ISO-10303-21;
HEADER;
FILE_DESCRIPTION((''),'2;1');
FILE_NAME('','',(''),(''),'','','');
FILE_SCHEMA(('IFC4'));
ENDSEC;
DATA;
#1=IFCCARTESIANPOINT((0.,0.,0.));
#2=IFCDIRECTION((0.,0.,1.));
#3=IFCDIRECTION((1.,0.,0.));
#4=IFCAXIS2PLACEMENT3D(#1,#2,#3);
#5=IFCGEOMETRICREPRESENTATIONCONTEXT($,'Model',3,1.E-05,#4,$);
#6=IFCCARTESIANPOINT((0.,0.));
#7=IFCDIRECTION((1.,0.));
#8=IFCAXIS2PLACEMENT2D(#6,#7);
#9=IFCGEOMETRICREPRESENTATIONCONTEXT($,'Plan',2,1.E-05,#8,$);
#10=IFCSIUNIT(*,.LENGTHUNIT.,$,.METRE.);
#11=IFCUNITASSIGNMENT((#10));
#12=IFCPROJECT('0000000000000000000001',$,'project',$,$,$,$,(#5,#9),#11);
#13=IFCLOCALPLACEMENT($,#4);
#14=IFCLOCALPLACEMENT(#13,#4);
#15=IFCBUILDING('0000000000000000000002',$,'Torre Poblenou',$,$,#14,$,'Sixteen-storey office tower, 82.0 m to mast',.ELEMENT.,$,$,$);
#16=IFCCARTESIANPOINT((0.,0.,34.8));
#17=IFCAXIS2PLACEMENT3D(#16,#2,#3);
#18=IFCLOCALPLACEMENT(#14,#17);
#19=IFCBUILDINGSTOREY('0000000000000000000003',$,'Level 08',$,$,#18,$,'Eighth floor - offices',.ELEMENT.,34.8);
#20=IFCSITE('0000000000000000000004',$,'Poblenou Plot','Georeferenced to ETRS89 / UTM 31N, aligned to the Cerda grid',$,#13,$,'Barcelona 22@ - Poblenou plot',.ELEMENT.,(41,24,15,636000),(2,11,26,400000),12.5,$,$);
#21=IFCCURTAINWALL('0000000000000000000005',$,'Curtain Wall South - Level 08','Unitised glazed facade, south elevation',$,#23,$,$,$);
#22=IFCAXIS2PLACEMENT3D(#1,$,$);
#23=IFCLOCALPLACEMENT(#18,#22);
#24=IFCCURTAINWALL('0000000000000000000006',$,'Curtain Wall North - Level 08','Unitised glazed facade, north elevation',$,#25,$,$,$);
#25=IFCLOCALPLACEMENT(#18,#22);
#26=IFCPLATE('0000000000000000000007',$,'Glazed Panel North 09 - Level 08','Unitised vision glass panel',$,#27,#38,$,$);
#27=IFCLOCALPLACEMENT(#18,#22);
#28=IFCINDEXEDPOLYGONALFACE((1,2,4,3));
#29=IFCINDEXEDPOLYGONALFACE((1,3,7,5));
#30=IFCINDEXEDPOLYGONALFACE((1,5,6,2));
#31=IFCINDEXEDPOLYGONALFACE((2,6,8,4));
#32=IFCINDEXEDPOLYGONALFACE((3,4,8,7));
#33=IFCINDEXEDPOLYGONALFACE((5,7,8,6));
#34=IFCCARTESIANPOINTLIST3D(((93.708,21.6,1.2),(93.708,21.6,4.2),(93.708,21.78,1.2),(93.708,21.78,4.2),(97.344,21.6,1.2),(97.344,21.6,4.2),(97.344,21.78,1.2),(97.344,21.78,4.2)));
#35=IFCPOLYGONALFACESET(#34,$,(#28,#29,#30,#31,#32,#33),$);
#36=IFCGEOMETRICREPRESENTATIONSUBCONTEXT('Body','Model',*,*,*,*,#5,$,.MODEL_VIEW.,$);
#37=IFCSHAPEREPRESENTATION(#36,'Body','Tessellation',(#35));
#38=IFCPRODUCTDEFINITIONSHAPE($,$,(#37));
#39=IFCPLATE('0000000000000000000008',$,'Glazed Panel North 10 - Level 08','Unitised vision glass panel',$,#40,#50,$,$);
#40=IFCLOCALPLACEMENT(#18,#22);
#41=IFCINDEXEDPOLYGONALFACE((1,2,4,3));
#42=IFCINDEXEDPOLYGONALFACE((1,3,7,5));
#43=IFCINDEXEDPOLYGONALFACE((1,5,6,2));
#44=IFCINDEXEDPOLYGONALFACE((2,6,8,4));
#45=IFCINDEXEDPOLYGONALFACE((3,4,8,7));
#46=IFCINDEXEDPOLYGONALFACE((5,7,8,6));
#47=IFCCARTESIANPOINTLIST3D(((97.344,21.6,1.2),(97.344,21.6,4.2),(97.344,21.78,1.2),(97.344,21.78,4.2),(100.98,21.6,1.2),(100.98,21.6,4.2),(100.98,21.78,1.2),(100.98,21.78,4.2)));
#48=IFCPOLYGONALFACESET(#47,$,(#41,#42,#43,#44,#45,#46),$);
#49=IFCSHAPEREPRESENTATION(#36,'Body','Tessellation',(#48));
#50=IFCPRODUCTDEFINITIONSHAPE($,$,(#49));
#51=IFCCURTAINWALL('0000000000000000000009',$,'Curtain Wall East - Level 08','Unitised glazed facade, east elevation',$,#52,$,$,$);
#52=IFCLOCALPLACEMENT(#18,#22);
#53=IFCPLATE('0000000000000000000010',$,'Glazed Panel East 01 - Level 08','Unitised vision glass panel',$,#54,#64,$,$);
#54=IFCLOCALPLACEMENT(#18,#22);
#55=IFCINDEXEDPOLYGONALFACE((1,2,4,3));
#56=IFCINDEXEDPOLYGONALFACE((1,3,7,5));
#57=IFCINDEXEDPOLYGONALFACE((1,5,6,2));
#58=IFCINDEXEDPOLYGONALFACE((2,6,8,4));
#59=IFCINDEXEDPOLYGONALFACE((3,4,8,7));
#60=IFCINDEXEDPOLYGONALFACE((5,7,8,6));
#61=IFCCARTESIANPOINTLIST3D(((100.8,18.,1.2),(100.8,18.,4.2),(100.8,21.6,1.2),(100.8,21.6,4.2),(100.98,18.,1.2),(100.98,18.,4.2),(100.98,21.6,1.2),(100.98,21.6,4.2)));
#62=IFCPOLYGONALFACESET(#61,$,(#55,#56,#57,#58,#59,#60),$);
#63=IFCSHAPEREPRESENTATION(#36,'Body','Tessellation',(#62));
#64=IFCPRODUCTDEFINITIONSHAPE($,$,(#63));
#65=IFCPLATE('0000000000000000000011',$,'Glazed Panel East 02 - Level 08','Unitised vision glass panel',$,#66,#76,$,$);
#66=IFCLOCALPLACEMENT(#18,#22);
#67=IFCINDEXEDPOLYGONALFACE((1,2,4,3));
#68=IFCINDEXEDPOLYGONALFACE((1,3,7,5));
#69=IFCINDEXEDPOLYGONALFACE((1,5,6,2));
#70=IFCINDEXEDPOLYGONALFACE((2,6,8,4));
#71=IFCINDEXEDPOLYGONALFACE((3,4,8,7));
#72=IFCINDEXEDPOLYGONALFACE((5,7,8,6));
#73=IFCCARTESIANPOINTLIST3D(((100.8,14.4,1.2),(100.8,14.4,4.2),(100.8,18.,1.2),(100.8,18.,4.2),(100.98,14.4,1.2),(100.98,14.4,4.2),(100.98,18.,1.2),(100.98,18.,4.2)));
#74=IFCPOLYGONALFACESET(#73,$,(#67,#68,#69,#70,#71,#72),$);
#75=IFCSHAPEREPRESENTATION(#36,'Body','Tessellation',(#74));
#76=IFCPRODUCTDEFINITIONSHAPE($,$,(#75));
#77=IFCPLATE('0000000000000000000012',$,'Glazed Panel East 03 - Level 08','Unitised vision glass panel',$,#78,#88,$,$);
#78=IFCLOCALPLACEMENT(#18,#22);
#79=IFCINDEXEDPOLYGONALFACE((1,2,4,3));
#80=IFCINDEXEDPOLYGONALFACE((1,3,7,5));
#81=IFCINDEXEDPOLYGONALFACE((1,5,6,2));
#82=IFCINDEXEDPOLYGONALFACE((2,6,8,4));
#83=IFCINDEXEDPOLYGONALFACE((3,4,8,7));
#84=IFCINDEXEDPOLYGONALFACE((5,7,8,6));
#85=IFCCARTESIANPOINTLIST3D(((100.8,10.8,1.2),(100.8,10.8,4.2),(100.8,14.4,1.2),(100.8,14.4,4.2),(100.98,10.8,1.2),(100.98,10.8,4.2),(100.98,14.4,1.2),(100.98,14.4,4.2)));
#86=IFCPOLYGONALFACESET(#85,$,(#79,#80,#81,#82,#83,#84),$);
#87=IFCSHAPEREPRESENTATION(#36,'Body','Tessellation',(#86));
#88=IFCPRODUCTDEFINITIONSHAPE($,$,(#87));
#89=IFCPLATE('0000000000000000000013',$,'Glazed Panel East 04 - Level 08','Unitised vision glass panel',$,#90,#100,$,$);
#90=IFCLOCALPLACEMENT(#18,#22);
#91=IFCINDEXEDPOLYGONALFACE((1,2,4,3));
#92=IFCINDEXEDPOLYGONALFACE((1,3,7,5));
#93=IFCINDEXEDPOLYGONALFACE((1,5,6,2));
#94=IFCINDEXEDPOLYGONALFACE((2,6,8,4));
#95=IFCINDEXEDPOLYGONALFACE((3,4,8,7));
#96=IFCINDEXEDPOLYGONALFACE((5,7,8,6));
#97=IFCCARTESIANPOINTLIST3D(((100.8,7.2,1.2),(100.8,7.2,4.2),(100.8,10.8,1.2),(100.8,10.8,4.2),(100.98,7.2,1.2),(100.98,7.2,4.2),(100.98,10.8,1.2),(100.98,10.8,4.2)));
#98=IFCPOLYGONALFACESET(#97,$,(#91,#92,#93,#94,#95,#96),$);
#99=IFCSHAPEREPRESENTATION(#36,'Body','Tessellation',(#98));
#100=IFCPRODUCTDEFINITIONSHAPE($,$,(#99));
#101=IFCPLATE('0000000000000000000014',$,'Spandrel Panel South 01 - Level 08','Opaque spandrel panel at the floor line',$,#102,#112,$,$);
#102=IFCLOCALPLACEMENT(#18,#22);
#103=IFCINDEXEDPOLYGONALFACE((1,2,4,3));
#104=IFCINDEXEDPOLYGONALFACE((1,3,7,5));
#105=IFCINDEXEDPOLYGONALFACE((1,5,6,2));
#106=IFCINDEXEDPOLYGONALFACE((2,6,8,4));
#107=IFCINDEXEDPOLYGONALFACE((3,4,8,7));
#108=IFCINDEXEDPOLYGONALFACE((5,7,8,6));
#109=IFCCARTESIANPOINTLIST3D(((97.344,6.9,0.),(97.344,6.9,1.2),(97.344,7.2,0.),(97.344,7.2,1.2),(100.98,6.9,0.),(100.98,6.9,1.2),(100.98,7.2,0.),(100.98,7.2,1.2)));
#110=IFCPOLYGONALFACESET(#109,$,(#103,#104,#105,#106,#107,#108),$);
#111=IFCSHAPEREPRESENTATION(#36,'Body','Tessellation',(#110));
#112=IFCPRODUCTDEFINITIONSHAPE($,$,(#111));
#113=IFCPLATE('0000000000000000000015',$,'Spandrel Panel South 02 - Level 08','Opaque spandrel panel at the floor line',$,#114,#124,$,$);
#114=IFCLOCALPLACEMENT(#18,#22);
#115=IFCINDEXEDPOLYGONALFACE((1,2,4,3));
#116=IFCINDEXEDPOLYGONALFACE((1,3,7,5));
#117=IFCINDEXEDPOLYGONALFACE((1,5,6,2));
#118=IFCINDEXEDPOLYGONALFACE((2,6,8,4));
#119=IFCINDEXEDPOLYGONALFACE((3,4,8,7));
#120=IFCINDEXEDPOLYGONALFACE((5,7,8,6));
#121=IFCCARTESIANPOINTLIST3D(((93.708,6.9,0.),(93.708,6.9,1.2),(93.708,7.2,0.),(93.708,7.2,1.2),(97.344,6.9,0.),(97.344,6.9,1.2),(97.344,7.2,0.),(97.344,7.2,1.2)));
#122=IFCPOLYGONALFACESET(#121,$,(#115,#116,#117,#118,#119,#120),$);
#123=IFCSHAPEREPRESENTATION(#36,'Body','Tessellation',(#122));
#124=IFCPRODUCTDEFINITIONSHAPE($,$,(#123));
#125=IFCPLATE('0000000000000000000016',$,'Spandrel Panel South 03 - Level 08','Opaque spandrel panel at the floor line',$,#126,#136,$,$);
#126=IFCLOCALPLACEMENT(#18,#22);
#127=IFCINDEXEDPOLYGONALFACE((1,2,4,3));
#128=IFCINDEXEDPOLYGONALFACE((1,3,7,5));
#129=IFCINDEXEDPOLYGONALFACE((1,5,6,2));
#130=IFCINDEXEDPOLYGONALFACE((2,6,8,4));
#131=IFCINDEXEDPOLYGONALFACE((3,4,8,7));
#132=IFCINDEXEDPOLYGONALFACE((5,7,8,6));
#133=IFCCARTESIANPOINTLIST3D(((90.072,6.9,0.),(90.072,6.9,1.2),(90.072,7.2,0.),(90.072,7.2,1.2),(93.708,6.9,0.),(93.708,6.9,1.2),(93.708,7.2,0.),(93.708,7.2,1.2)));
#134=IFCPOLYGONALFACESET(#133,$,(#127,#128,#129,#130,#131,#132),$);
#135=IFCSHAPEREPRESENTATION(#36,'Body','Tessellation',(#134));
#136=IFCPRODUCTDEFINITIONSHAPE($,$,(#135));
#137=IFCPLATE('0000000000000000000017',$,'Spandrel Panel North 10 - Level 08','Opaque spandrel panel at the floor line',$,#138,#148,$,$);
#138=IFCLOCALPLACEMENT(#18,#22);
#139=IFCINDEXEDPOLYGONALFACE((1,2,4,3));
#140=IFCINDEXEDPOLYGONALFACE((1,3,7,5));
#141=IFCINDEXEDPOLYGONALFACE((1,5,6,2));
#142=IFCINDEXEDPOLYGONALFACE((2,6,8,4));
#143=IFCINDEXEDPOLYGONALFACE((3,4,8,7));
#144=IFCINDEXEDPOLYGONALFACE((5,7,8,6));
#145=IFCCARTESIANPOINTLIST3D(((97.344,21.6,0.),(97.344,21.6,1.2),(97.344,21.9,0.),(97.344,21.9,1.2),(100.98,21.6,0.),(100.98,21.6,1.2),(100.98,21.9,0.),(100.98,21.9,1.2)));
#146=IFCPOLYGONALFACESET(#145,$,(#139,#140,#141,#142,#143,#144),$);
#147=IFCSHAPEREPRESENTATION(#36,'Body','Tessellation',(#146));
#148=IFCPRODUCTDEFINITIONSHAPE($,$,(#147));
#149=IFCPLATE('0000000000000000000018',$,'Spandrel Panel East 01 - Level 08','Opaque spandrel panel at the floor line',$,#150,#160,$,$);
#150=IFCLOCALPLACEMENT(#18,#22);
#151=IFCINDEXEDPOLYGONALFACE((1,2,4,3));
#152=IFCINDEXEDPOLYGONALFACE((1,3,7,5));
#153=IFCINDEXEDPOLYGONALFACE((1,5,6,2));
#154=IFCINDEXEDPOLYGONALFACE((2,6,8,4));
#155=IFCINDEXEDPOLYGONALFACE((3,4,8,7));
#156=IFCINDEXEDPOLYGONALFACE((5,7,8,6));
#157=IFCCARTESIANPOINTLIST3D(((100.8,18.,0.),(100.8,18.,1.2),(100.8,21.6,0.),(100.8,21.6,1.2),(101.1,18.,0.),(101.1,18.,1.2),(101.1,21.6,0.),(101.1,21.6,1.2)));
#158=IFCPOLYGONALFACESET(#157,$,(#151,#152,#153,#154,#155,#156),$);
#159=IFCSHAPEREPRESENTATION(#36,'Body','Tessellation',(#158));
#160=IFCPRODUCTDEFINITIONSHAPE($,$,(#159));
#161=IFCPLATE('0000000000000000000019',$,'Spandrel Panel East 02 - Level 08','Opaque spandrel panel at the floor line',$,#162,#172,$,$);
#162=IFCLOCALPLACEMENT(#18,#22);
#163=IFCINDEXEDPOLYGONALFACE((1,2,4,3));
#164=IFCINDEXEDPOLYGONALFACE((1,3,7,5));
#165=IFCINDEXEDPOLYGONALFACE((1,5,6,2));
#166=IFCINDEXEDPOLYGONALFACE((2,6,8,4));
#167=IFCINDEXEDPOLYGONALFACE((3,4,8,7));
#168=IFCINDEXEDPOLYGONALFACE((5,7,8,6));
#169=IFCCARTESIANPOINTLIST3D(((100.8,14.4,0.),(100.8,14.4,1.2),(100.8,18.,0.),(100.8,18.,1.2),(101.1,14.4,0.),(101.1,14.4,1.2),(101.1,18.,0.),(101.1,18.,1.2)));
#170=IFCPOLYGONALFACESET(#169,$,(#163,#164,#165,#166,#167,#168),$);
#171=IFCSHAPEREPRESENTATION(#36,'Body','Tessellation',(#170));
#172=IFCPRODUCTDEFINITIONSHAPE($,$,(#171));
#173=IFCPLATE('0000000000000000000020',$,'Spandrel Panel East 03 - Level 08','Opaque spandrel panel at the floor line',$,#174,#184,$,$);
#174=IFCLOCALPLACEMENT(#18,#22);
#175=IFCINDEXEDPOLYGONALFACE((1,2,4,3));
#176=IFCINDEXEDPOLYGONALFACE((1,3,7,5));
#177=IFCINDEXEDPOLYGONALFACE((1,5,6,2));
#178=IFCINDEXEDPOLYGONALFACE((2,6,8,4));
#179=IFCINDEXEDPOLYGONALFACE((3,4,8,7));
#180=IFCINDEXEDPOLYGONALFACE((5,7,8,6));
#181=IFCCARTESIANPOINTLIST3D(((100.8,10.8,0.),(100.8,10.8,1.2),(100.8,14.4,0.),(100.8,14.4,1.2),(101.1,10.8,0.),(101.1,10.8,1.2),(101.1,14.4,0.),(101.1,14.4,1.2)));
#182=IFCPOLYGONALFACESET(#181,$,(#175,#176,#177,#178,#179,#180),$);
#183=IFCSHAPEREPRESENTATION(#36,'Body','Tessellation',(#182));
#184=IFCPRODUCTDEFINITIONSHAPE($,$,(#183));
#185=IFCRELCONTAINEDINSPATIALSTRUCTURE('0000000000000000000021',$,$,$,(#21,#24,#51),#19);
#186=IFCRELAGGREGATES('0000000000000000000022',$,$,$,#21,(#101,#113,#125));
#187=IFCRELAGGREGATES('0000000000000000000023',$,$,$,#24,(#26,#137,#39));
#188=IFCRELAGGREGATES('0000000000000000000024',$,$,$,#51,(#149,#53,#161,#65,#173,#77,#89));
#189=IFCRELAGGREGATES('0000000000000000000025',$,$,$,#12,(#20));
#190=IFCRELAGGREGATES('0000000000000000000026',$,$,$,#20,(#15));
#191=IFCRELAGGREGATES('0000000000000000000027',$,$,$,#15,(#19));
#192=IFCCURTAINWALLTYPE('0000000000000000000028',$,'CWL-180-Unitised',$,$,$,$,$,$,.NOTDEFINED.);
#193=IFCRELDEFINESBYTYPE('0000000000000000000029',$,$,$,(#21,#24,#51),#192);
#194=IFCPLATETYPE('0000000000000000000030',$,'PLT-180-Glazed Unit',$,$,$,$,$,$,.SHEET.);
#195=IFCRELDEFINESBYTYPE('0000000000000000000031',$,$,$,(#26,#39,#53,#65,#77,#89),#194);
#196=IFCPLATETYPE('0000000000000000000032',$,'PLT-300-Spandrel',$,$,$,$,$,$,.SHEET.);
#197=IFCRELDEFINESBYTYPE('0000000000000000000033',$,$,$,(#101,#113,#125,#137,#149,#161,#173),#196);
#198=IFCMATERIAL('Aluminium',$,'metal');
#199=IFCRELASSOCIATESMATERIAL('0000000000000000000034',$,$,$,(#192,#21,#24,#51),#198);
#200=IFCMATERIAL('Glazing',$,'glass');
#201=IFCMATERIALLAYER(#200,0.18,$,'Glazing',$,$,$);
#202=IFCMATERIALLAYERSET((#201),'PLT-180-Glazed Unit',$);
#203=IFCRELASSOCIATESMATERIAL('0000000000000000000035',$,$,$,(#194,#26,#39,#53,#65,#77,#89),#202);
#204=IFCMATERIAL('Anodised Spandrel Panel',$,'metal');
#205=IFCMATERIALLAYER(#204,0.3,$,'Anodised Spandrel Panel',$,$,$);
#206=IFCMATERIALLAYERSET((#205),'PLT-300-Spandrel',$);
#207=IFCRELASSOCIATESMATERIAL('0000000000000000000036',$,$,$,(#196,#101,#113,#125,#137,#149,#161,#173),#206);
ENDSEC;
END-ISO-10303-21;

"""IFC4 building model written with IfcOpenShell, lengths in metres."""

from ifc_helpers import new_model, si_unit, frame, origin_with_axes, origin_2d_with_axis, place, context, subcontext, project, spatial, line, indexed_curve, outline, extrude, material, layer, layer_set, layer_usage, type_object, element, aggregate, save


model = new_model("IFC4")

# Units and contexts
model_context = context("Model", 3, precision=1e-05, world=origin_with_axes())
plan_context = context("Plan", 2, precision=1e-05, world=origin_2d_with_axis())
body_context = subcontext(model_context, "Body", "Model", "MODEL_VIEW")
ifc_project = project(units=[si_unit("LENGTHUNIT", "METRE")], contexts=[model_context, plan_context])

# Site, building, storey
site_placement = place(None, origin_with_axes())
site = spatial("IfcSite", under=ifc_project, at=site_placement, Name="Poblenou Plot", Description="Georeferenced to ETRS89 / UTM 31N, aligned to the Cerda grid", LongName="Barcelona 22@ - Poblenou plot", CompositionType="ELEMENT", RefLatitude=(41, 24, 15, 636000), RefLongitude=(2, 11, 26, 400000), RefElevation=12.5)
building_placement = place(site_placement, origin_with_axes())
building = spatial("IfcBuilding", under=site, at=building_placement, Name="Torre Poblenou", LongName="Sixteen-storey office tower, 82.0 m to mast", CompositionType="ELEMENT")
storey_placement = place(building_placement, frame((0.0, 0.0, 34.8), z_axis=(0.0, 0.0, 1.0), x_axis=(1.0, 0.0, 0.0)))
storey = spatial("IfcBuildingStorey", under=building, at=storey_placement, Name="Level 08", LongName="Eighth floor - offices", CompositionType="ELEMENT", Elevation=34.8)

# Curtain walls, plates
ifc_material_1 = material(Name="Aluminium", Category="metal")
curtain_wall_type = type_object("IfcCurtainWallType", Name="CWL-180-Unitised", PredefinedType="NOTDEFINED", material=ifc_material_1)
curtain_wall_1_placement = place(storey_placement, frame((100.98, 7.2, 0.0), z_axis=(0.0, 0.0, 1.0), x_axis=(-1.0, 0.0, 0.0)))
curtain_wall_1 = element("IfcCurtainWall", 1, at=curtain_wall_1_placement, inside=storey, type_object=curtain_wall_type, material=ifc_material_1, Name="Curtain Wall South - Level 08", Description="Unitised glazed facade, south elevation")
ifc_material_2 = material(Name="Glazing", Category="glass")
ifc_layer_1 = layer(ifc_material_2, 0.18, Name="Glazing")
ifc_layer_set_1 = layer_set([ifc_layer_1], Name="PLT-180-Glazed Unit")
plate_type_1 = type_object("IfcPlateType", Name="PLT-180-Glazed Unit", PredefinedType="SHEET", material=ifc_layer_set_1)
curtain_wall_2_placement = place(storey_placement, frame((64.62, 21.6, 0.0), z_axis=(0.0, 0.0, 1.0), x_axis=(1.0, 0.0, 0.0)))
curtain_wall_2 = element("IfcCurtainWall", 2, at=curtain_wall_2_placement, inside=storey, type_object=curtain_wall_type, material=ifc_material_1, Name="Curtain Wall North - Level 08", Description="Unitised glazed facade, north elevation")
ifc_layer_usage_1 = layer_usage(ifc_layer_set_1, "AXIS2", "POSITIVE", 0.0)
plate_1_placement = place(curtain_wall_2_placement, frame((29.088, 0.0, 1.2), z_axis=(0.0, 0.0, 1.0), x_axis=(1.0, 0.0, 0.0)))
plate_1 = element("IfcPlate", 3, at=plate_1_placement, type_object=plate_type_1, material=ifc_layer_usage_1, Name="Glazed Panel North 09 - Level 08", Description="Unitised vision glass panel", context=body_context, shape_type="SweptSolid", body=[
    extrude(outline(indexed_curve([(0.0, 0.0), (3.636, 0.0), (3.636, 0.18), (0.0, 0.18)], segments=[line(1, 2, 3, 4, 1)])), origin_with_axes(), (0.0, 0.0, 1.0), 3.0),
])
ifc_layer_usage_2 = layer_usage(ifc_layer_set_1, "AXIS2", "POSITIVE", 0.0)
plate_2_placement = place(curtain_wall_2_placement, frame((32.724, 0.0, 1.2), z_axis=(0.0, 0.0, 1.0), x_axis=(1.0, 0.0, 0.0)))
plate_2 = element("IfcPlate", 4, at=plate_2_placement, type_object=plate_type_1, material=ifc_layer_usage_2, Name="Glazed Panel North 10 - Level 08", Description="Unitised vision glass panel", context=body_context, shape_type="SweptSolid", body=[
    extrude(outline(indexed_curve([(0.0, 0.0), (3.636, 0.0), (3.636, 0.18), (0.0, 0.18)], segments=[line(1, 2, 3, 4, 1)])), origin_with_axes(), (0.0, 0.0, 1.0), 3.0),
])
curtain_wall_3_placement = place(storey_placement, frame((100.8, 21.6, 0.0), z_axis=(0.0, 0.0, 1.0), x_axis=(0.0, -1.0, 0.0)))
curtain_wall_3 = element("IfcCurtainWall", 5, at=curtain_wall_3_placement, inside=storey, type_object=curtain_wall_type, material=ifc_material_1, Name="Curtain Wall East - Level 08", Description="Unitised glazed facade, east elevation")
ifc_layer_usage_3 = layer_usage(ifc_layer_set_1, "AXIS2", "POSITIVE", 0.0)
plate_3_placement = place(curtain_wall_3_placement, frame((0.0, 0.0, 1.2), z_axis=(0.0, 0.0, 1.0), x_axis=(1.0, 0.0, 0.0)))
plate_3 = element("IfcPlate", 6, at=plate_3_placement, type_object=plate_type_1, material=ifc_layer_usage_3, Name="Glazed Panel East 01 - Level 08", Description="Unitised vision glass panel", context=body_context, shape_type="SweptSolid", body=[
    extrude(outline(indexed_curve([(0.0, 0.0), (3.6, 0.0), (3.6, 0.18), (0.0, 0.18)], segments=[line(1, 2, 3, 4, 1)])), origin_with_axes(), (0.0, 0.0, 1.0), 3.0),
])
ifc_layer_usage_4 = layer_usage(ifc_layer_set_1, "AXIS2", "POSITIVE", 0.0)
plate_4_placement = place(curtain_wall_3_placement, frame((3.6, 0.0, 1.2), z_axis=(0.0, 0.0, 1.0), x_axis=(1.0, 0.0, 0.0)))
plate_4 = element("IfcPlate", 7, at=plate_4_placement, type_object=plate_type_1, material=ifc_layer_usage_4, Name="Glazed Panel East 02 - Level 08", Description="Unitised vision glass panel", context=body_context, shape_type="SweptSolid", body=[
    extrude(outline(indexed_curve([(0.0, 0.0), (3.6, 0.0), (3.6, 0.18), (0.0, 0.18)], segments=[line(1, 2, 3, 4, 1)])), origin_with_axes(), (0.0, 0.0, 1.0), 3.0),
])
ifc_layer_usage_5 = layer_usage(ifc_layer_set_1, "AXIS2", "POSITIVE", 0.0)
plate_5_placement = place(curtain_wall_3_placement, frame((7.2, 0.0, 1.2), z_axis=(0.0, 0.0, 1.0), x_axis=(1.0, 0.0, 0.0)))
plate_5 = element("IfcPlate", 8, at=plate_5_placement, type_object=plate_type_1, material=ifc_layer_usage_5, Name="Glazed Panel East 03 - Level 08", Description="Unitised vision glass panel", context=body_context, shape_type="SweptSolid", body=[
    extrude(outline(indexed_curve([(0.0, 0.0), (3.6, 0.0), (3.6, 0.18), (0.0, 0.18)], segments=[line(1, 2, 3, 4, 1)])), origin_with_axes(), (0.0, 0.0, 1.0), 3.0),
])
ifc_layer_usage_6 = layer_usage(ifc_layer_set_1, "AXIS2", "POSITIVE", 0.0)
plate_6_placement = place(curtain_wall_3_placement, frame((10.8, 0.0, 1.2), z_axis=(0.0, 0.0, 1.0), x_axis=(1.0, 0.0, 0.0)))
plate_6 = element("IfcPlate", 9, at=plate_6_placement, type_object=plate_type_1, material=ifc_layer_usage_6, Name="Glazed Panel East 04 - Level 08", Description="Unitised vision glass panel", context=body_context, shape_type="SweptSolid", body=[
    extrude(outline(indexed_curve([(0.0, 0.0), (3.6, 0.0), (3.6, 0.18), (0.0, 0.18)], segments=[line(1, 2, 3, 4, 1)])), origin_with_axes(), (0.0, 0.0, 1.0), 3.0),
])

# Plates
ifc_material_3 = material(Name="Anodised Spandrel Panel", Category="metal")
ifc_layer_2 = layer(ifc_material_3, 0.3, Name="Anodised Spandrel Panel")
ifc_layer_set_2 = layer_set([ifc_layer_2], Name="PLT-300-Spandrel")
ifc_layer_usage_7 = layer_usage(ifc_layer_set_2, "AXIS2", "POSITIVE", 0.0)
plate_type_2 = type_object("IfcPlateType", Name="PLT-300-Spandrel", PredefinedType="SHEET", material=ifc_layer_set_2)
plate_7_placement = place(curtain_wall_1_placement, origin_with_axes())
plate_7 = element("IfcPlate", 10, at=plate_7_placement, type_object=plate_type_2, material=ifc_layer_usage_7, Name="Spandrel Panel South 01 - Level 08", Description="Opaque spandrel panel at the floor line", context=body_context, shape_type="SweptSolid", body=[
    extrude(outline(indexed_curve([(0.0, 0.0), (3.636, 0.0), (3.636, 0.3), (0.0, 0.3)], segments=[line(1, 2, 3, 4, 1)])), origin_with_axes(), (0.0, 0.0, 1.0), 1.2),
])
ifc_layer_usage_8 = layer_usage(ifc_layer_set_2, "AXIS2", "POSITIVE", 0.0)
plate_8_placement = place(curtain_wall_1_placement, frame((3.636, 0.0, 0.0), z_axis=(0.0, 0.0, 1.0), x_axis=(1.0, 0.0, 0.0)))
plate_8 = element("IfcPlate", 11, at=plate_8_placement, type_object=plate_type_2, material=ifc_layer_usage_8, Name="Spandrel Panel South 02 - Level 08", Description="Opaque spandrel panel at the floor line", context=body_context, shape_type="SweptSolid", body=[
    extrude(outline(indexed_curve([(0.0, 0.0), (3.636, 0.0), (3.636, 0.3), (0.0, 0.3)], segments=[line(1, 2, 3, 4, 1)])), origin_with_axes(), (0.0, 0.0, 1.0), 1.2),
])
ifc_layer_usage_9 = layer_usage(ifc_layer_set_2, "AXIS2", "POSITIVE", 0.0)
plate_9_placement = place(curtain_wall_1_placement, frame((7.272, 0.0, 0.0), z_axis=(0.0, 0.0, 1.0), x_axis=(1.0, 0.0, 0.0)))
plate_9 = element("IfcPlate", 12, at=plate_9_placement, type_object=plate_type_2, material=ifc_layer_usage_9, Name="Spandrel Panel South 03 - Level 08", Description="Opaque spandrel panel at the floor line", context=body_context, shape_type="SweptSolid", body=[
    extrude(outline(indexed_curve([(0.0, 0.0), (3.636, 0.0), (3.636, 0.3), (0.0, 0.3)], segments=[line(1, 2, 3, 4, 1)])), origin_with_axes(), (0.0, 0.0, 1.0), 1.2),
])
aggregate(curtain_wall_1, [plate_7, plate_8, plate_9])
ifc_layer_usage_10 = layer_usage(ifc_layer_set_2, "AXIS2", "POSITIVE", 0.0)
plate_10_placement = place(curtain_wall_2_placement, frame((32.724, 0.0, 0.0), z_axis=(0.0, 0.0, 1.0), x_axis=(1.0, 0.0, 0.0)))
plate_10 = element("IfcPlate", 13, at=plate_10_placement, type_object=plate_type_2, material=ifc_layer_usage_10, Name="Spandrel Panel North 10 - Level 08", Description="Opaque spandrel panel at the floor line", context=body_context, shape_type="SweptSolid", body=[
    extrude(outline(indexed_curve([(0.0, 0.0), (3.636, 0.0), (3.636, 0.3), (0.0, 0.3)], segments=[line(1, 2, 3, 4, 1)])), origin_with_axes(), (0.0, 0.0, 1.0), 1.2),
])
aggregate(curtain_wall_2, [plate_1, plate_10, plate_2])
ifc_layer_usage_11 = layer_usage(ifc_layer_set_2, "AXIS2", "POSITIVE", 0.0)
plate_11_placement = place(curtain_wall_3_placement, origin_with_axes())
plate_11 = element("IfcPlate", 14, at=plate_11_placement, type_object=plate_type_2, material=ifc_layer_usage_11, Name="Spandrel Panel East 01 - Level 08", Description="Opaque spandrel panel at the floor line", context=body_context, shape_type="SweptSolid", body=[
    extrude(outline(indexed_curve([(0.0, 0.0), (3.6, 0.0), (3.6, 0.3), (0.0, 0.3)], segments=[line(1, 2, 3, 4, 1)])), origin_with_axes(), (0.0, 0.0, 1.0), 1.2),
])
ifc_layer_usage_12 = layer_usage(ifc_layer_set_2, "AXIS2", "POSITIVE", 0.0)
plate_12_placement = place(curtain_wall_3_placement, frame((3.6, 0.0, 0.0), z_axis=(0.0, 0.0, 1.0), x_axis=(1.0, 0.0, 0.0)))
plate_12 = element("IfcPlate", 15, at=plate_12_placement, type_object=plate_type_2, material=ifc_layer_usage_12, Name="Spandrel Panel East 02 - Level 08", Description="Opaque spandrel panel at the floor line", context=body_context, shape_type="SweptSolid", body=[
    extrude(outline(indexed_curve([(0.0, 0.0), (3.6, 0.0), (3.6, 0.3), (0.0, 0.3)], segments=[line(1, 2, 3, 4, 1)])), origin_with_axes(), (0.0, 0.0, 1.0), 1.2),
])
ifc_layer_usage_13 = layer_usage(ifc_layer_set_2, "AXIS2", "POSITIVE", 0.0)
plate_13_placement = place(curtain_wall_3_placement, frame((7.2, 0.0, 0.0), z_axis=(0.0, 0.0, 1.0), x_axis=(1.0, 0.0, 0.0)))
plate_13 = element("IfcPlate", 16, at=plate_13_placement, type_object=plate_type_2, material=ifc_layer_usage_13, Name="Spandrel Panel East 03 - Level 08", Description="Opaque spandrel panel at the floor line", context=body_context, shape_type="SweptSolid", body=[
    extrude(outline(indexed_curve([(0.0, 0.0), (3.6, 0.0), (3.6, 0.3), (0.0, 0.3)], segments=[line(1, 2, 3, 4, 1)])), origin_with_axes(), (0.0, 0.0, 1.0), 1.2),
])
aggregate(curtain_wall_3, [plate_11, plate_3, plate_12, plate_4, plate_13, plate_5, plate_6])

save(model, "model.ifc")
